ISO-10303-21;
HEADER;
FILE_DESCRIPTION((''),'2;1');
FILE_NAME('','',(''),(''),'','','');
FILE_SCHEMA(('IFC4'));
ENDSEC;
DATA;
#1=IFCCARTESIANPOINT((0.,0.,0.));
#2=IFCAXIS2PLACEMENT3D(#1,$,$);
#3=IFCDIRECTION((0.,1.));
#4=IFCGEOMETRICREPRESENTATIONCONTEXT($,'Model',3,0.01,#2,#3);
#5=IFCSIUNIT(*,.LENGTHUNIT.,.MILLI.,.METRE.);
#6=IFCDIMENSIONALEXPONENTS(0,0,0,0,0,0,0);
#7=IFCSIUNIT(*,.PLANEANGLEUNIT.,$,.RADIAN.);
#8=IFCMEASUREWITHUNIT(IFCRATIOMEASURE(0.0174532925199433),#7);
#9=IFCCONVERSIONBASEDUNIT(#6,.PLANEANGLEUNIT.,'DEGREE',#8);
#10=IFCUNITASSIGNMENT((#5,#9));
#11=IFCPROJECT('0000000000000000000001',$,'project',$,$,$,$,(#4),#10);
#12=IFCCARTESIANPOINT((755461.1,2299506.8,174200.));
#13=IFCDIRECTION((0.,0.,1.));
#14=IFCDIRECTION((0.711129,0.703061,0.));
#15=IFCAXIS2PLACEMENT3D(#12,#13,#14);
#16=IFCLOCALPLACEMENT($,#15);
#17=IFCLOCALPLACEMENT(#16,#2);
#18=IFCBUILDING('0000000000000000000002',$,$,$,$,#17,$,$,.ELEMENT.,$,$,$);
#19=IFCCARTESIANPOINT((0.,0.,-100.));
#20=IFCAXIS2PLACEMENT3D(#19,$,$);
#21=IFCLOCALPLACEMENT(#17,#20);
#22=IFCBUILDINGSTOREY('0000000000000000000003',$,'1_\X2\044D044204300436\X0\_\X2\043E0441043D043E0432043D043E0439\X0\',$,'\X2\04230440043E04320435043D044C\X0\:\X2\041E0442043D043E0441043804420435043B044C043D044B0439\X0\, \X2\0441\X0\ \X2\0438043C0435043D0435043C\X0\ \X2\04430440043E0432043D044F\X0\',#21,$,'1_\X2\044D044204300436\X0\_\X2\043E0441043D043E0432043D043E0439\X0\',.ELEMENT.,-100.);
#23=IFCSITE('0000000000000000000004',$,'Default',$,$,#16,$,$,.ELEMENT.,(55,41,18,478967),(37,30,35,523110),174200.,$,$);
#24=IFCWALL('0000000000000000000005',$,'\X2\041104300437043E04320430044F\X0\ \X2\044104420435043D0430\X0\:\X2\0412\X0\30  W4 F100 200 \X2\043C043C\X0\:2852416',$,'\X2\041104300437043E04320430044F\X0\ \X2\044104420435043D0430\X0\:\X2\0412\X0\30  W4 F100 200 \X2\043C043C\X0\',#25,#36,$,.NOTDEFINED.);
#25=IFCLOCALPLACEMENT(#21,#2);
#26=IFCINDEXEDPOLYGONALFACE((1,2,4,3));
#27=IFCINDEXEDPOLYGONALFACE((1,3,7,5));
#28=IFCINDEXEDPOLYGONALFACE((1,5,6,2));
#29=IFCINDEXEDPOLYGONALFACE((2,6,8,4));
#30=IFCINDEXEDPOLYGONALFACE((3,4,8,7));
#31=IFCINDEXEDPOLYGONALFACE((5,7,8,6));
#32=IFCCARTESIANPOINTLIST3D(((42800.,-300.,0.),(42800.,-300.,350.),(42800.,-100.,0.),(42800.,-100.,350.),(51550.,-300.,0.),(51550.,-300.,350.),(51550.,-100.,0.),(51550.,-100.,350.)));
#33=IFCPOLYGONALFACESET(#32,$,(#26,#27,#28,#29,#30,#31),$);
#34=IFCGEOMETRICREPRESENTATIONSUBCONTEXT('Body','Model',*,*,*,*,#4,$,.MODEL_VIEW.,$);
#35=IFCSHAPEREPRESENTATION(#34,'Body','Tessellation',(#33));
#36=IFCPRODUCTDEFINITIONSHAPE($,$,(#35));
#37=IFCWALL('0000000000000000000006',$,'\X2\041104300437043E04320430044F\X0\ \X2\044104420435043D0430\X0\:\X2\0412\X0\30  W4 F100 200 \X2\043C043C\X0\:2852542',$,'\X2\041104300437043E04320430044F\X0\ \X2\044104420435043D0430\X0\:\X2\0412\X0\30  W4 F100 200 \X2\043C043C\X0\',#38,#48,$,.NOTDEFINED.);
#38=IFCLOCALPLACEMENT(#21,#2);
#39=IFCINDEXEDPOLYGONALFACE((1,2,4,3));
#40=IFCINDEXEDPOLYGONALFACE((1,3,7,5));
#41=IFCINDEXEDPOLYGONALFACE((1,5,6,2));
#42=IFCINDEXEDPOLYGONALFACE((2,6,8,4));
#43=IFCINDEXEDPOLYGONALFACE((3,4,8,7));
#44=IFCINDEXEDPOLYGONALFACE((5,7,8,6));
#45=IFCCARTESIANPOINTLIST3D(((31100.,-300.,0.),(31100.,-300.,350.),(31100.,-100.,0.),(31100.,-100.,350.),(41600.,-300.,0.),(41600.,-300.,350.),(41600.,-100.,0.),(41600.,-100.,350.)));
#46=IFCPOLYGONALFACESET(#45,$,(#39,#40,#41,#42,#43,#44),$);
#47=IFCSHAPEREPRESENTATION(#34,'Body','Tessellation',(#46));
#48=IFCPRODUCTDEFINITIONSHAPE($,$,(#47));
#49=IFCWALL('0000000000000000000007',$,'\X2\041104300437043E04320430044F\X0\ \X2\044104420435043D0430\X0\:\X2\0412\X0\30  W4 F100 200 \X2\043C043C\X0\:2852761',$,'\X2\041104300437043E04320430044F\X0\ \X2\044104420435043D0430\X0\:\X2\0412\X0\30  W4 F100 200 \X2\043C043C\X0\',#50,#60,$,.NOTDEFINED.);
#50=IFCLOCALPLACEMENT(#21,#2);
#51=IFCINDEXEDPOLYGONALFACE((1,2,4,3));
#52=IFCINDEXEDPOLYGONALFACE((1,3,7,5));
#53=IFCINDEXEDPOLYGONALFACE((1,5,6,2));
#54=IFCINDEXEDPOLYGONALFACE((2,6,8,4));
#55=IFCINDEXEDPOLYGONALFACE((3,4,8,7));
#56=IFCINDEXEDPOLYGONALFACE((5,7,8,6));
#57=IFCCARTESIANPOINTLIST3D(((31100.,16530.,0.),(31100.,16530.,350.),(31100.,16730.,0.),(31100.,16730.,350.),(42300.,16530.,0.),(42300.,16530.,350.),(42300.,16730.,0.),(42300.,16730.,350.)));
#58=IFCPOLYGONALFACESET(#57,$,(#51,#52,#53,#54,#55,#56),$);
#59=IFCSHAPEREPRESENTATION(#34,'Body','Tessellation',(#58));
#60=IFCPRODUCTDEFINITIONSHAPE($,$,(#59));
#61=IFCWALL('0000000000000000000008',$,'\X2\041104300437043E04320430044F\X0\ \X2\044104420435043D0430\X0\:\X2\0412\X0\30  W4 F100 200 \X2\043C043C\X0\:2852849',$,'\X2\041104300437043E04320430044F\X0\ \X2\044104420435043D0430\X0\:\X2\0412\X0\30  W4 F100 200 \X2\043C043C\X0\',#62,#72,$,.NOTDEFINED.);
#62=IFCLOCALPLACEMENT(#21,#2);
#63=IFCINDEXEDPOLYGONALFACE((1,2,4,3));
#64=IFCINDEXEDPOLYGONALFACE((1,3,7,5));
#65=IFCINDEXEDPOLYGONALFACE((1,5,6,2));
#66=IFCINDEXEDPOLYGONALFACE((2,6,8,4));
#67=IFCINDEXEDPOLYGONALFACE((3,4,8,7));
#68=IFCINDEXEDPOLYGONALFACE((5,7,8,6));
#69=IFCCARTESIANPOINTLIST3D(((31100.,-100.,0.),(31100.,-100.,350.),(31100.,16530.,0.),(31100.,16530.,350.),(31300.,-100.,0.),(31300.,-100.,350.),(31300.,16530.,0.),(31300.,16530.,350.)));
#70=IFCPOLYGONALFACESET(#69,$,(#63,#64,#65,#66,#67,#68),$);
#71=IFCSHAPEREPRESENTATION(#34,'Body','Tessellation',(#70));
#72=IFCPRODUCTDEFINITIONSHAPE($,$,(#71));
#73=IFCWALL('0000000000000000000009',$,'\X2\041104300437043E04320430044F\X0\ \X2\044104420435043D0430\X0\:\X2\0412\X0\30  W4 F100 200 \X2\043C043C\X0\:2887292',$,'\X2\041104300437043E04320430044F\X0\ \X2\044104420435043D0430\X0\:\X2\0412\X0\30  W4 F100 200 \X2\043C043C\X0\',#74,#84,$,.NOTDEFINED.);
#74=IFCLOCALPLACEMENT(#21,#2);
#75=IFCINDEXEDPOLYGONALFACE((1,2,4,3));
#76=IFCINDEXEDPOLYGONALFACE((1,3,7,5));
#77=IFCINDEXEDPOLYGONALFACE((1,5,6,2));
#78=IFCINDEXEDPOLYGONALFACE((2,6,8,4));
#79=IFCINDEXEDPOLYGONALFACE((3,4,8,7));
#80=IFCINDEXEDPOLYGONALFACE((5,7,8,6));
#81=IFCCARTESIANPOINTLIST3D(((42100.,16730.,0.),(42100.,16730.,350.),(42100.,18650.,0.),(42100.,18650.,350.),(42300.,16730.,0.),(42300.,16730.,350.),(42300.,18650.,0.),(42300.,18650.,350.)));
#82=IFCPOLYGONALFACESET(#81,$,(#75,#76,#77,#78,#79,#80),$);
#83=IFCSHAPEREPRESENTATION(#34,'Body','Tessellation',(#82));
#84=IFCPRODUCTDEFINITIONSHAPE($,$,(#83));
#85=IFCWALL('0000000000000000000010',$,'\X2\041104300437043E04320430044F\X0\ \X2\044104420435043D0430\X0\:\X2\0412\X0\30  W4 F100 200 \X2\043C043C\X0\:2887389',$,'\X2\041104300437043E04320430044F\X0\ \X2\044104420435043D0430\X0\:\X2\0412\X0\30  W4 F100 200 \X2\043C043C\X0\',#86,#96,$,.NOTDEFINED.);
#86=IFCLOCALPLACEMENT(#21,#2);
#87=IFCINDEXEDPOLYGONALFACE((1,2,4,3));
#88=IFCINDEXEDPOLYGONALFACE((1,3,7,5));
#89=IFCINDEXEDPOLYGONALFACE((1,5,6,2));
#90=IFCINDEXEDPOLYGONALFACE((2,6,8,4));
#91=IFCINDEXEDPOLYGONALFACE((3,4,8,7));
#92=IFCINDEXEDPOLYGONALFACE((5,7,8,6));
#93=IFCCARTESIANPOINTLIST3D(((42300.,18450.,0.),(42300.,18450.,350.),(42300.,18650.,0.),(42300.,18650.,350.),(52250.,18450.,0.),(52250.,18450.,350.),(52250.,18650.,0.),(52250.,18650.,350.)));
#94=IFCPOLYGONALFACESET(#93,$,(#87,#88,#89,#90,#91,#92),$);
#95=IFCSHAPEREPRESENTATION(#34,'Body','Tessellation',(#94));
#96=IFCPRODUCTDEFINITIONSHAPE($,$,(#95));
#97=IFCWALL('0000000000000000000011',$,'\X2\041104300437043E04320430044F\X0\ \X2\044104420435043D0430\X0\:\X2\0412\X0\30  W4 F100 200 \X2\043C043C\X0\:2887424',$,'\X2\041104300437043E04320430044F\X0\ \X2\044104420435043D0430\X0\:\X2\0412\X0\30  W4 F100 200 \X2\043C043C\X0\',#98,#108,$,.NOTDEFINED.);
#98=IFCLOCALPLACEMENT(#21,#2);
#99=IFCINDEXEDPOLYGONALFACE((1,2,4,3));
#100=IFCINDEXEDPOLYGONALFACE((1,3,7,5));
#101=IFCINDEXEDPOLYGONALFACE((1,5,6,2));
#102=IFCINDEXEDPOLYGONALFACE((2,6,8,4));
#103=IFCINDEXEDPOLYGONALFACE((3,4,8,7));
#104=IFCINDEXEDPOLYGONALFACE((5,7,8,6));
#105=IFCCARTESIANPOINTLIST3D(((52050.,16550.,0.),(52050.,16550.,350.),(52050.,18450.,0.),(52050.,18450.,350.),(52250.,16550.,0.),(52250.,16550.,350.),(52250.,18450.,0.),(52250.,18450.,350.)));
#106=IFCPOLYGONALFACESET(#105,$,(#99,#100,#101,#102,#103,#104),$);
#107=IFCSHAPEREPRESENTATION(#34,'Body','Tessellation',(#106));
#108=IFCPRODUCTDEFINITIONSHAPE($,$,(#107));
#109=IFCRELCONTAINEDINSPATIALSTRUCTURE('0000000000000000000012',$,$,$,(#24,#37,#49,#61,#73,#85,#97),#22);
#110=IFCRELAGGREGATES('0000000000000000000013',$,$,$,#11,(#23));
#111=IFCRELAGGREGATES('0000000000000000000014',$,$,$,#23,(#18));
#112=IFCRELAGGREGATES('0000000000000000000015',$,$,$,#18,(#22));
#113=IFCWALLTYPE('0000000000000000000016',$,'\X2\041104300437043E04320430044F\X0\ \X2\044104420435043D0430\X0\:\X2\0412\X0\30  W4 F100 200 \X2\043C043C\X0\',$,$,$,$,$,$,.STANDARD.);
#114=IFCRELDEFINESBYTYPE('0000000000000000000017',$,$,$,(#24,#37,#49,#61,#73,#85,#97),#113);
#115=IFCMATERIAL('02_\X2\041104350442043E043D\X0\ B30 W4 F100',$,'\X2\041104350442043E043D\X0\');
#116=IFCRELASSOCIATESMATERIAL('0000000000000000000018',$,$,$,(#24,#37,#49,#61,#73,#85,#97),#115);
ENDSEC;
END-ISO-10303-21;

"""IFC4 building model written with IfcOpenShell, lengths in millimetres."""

from ifc_helpers import new_model, entity, si_unit, converted_unit, direction, frame, origin, place, context, subcontext, project, spatial, indexed_curve, outline, extrude, material, type_object, element, save


model = new_model("IFC4")

# Units and contexts
model_context = context("Model", 3, precision=0.01, world=origin(), true_north=direction((0.0, 1.0)))
body_context = subcontext(model_context, "Body", "Model", "MODEL_VIEW")
ifc_project = project(units=[si_unit("LENGTHUNIT", "METRE", prefix="MILLI"), converted_unit("PLANEANGLEUNIT", "DEGREE", entity("IfcRatioMeasure", 0.0174532925199433), si_unit("PLANEANGLEUNIT", "RADIAN"), dimensions=[0, 0, 0, 0, 0, 0, 0])], contexts=[model_context])

# Site, building, storey
site_placement = place(None, frame((755461.1, 2299506.8, 174200.0), z_axis=(0.0, 0.0, 1.0), x_axis=(0.711129, 0.703061, 0.0)))
site = spatial("IfcSite", under=ifc_project, at=site_placement, Name="Default", CompositionType="ELEMENT", RefLatitude=(55, 41, 18, 478967), RefLongitude=(37, 30, 35, 523110), RefElevation=174200.0)
building_placement = place(site_placement, origin())
building = spatial("IfcBuilding", under=site, at=building_placement, CompositionType="ELEMENT")
storey_placement = place(building_placement, frame((0.0, 0.0, -100.0)))
storey = spatial("IfcBuildingStorey", under=building, at=storey_placement, Name="1_этаж_основной", ObjectType="Уровень:Относительный, с именем уровня", LongName="1_этаж_основной", CompositionType="ELEMENT", Elevation=-100.0)

# Shared definitions
ifc_material_1 = material(Name="02_Бетон B30 W4 F100", Category="Бетон")

# Walls
wall_type_1 = type_object("IfcWallType", Name="Базовая стена:В30  W4 F100 200 мм", PredefinedType="STANDARD")
wall_1_placement = place(storey_placement, frame((51550.0, -200.0, 0.0), z_axis=(0.0, 0.0, 1.0), x_axis=(-1.0, 0.0, 0.0)))
element("IfcWall", 1, at=wall_1_placement, inside=storey, type_object=wall_type_1, material=ifc_material_1, Name="Базовая стена:В30  W4 F100 200 мм:2852416", ObjectType="Базовая стена:В30  W4 F100 200 мм", PredefinedType="NOTDEFINED", context=body_context, shape_type="SweptSolid", body=[
    extrude(outline(indexed_curve([(8750.0, 100.0), (0.0, 100.0), (0.0, -100.0), (8750.0, -100.0), (8750.0, 100.0)], self_intersect=False)), origin(), (0.0, 0.0, 1.0), 350.0),
])
wall_2_placement = place(storey_placement, frame((41600.0, -200.0, 0.0), z_axis=(0.0, 0.0, 1.0), x_axis=(-1.0, 0.0, 0.0)))
element("IfcWall", 2, at=wall_2_placement, inside=storey, type_object=wall_type_1, material=ifc_material_1, Name="Базовая стена:В30  W4 F100 200 мм:2852542", ObjectType="Базовая стена:В30  W4 F100 200 мм", PredefinedType="NOTDEFINED", context=body_context, shape_type="SweptSolid", body=[
    extrude(outline(indexed_curve([(10500.0, 100.0), (0.0, 100.0), (0.0, -100.0), (10500.0, -100.0), (10500.0, 100.0)], self_intersect=False)), origin(), (0.0, 0.0, 1.0), 350.0),
])
wall_3_placement = place(storey_placement, frame((42300.0, 16630.0, 0.0), z_axis=(0.0, 0.0, 1.0), x_axis=(-1.0, 0.0, 0.0)))
element("IfcWall", 3, at=wall_3_placement, inside=storey, type_object=wall_type_1, material=ifc_material_1, Name="Базовая стена:В30  W4 F100 200 мм:2852761", ObjectType="Базовая стена:В30  W4 F100 200 мм", PredefinedType="NOTDEFINED", context=body_context, shape_type="SweptSolid", body=[
    extrude(outline(indexed_curve([(11200.0, 100.0), (0.0, 100.0), (0.0, -100.0), (11200.0, -100.0), (11200.0, 100.0)], self_intersect=False)), origin(), (0.0, 0.0, 1.0), 350.0),
])
wall_4_placement = place(storey_placement, frame((31200.0, 16530.0, 0.0), z_axis=(0.0, 0.0, 1.0), x_axis=(0.0, -1.0, 0.0)))
element("IfcWall", 4, at=wall_4_placement, inside=storey, type_object=wall_type_1, material=ifc_material_1, Name="Базовая стена:В30  W4 F100 200 мм:2852849", ObjectType="Базовая стена:В30  W4 F100 200 мм", PredefinedType="NOTDEFINED", context=body_context, shape_type="SweptSolid", body=[
    extrude(outline(indexed_curve([(16630.0, 100.0), (0.0, 100.0), (0.0, -100.0), (16630.0, -100.0), (16630.0, 100.0)], self_intersect=False)), origin(), (0.0, 0.0, 1.0), 350.0),
])
wall_5_placement = place(storey_placement, frame((42200.0, 16730.0, 0.0), z_axis=(0.0, 0.0, 1.0), x_axis=(0.0, 1.0, 0.0)))
element("IfcWall", 5, at=wall_5_placement, inside=storey, type_object=wall_type_1, material=ifc_material_1, Name="Базовая стена:В30  W4 F100 200 мм:2887292", ObjectType="Базовая стена:В30  W4 F100 200 мм", PredefinedType="NOTDEFINED", context=body_context, shape_type="SweptSolid", body=[
    extrude(outline(indexed_curve([(1920.0, 100.0), (0.0, 100.0), (0.0, -100.0), (1920.0, -100.0), (1920.0, 100.0)], self_intersect=False)), origin(), (0.0, 0.0, 1.0), 350.0),
])
wall_6_placement = place(storey_placement, frame((42300.0, 18550.0, 0.0)))
element("IfcWall", 6, at=wall_6_placement, inside=storey, type_object=wall_type_1, material=ifc_material_1, Name="Базовая стена:В30  W4 F100 200 мм:2887389", ObjectType="Базовая стена:В30  W4 F100 200 мм", PredefinedType="NOTDEFINED", context=body_context, shape_type="SweptSolid", body=[
    extrude(outline(indexed_curve([(9950.0, 100.0), (0.0, 100.0), (0.0, -100.0), (9950.0, -100.0), (9950.0, 100.0)], self_intersect=False)), origin(), (0.0, 0.0, 1.0), 350.0),
])
wall_7_placement = place(storey_placement, frame((52150.0, 18450.0, 0.0), z_axis=(0.0, 0.0, 1.0), x_axis=(0.0, -1.0, 0.0)))
element("IfcWall", 7, at=wall_7_placement, inside=storey, type_object=wall_type_1, material=ifc_material_1, Name="Базовая стена:В30  W4 F100 200 мм:2887424", ObjectType="Базовая стена:В30  W4 F100 200 мм", PredefinedType="NOTDEFINED", context=body_context, shape_type="SweptSolid", body=[
    extrude(outline(indexed_curve([(1900.0, 100.0), (0.0, 100.0), (0.0, -100.0), (1900.0, -100.0), (1900.0, 100.0)], self_intersect=False)), origin(), (0.0, 0.0, 1.0), 350.0),
])

save(model, "model.ifc")
